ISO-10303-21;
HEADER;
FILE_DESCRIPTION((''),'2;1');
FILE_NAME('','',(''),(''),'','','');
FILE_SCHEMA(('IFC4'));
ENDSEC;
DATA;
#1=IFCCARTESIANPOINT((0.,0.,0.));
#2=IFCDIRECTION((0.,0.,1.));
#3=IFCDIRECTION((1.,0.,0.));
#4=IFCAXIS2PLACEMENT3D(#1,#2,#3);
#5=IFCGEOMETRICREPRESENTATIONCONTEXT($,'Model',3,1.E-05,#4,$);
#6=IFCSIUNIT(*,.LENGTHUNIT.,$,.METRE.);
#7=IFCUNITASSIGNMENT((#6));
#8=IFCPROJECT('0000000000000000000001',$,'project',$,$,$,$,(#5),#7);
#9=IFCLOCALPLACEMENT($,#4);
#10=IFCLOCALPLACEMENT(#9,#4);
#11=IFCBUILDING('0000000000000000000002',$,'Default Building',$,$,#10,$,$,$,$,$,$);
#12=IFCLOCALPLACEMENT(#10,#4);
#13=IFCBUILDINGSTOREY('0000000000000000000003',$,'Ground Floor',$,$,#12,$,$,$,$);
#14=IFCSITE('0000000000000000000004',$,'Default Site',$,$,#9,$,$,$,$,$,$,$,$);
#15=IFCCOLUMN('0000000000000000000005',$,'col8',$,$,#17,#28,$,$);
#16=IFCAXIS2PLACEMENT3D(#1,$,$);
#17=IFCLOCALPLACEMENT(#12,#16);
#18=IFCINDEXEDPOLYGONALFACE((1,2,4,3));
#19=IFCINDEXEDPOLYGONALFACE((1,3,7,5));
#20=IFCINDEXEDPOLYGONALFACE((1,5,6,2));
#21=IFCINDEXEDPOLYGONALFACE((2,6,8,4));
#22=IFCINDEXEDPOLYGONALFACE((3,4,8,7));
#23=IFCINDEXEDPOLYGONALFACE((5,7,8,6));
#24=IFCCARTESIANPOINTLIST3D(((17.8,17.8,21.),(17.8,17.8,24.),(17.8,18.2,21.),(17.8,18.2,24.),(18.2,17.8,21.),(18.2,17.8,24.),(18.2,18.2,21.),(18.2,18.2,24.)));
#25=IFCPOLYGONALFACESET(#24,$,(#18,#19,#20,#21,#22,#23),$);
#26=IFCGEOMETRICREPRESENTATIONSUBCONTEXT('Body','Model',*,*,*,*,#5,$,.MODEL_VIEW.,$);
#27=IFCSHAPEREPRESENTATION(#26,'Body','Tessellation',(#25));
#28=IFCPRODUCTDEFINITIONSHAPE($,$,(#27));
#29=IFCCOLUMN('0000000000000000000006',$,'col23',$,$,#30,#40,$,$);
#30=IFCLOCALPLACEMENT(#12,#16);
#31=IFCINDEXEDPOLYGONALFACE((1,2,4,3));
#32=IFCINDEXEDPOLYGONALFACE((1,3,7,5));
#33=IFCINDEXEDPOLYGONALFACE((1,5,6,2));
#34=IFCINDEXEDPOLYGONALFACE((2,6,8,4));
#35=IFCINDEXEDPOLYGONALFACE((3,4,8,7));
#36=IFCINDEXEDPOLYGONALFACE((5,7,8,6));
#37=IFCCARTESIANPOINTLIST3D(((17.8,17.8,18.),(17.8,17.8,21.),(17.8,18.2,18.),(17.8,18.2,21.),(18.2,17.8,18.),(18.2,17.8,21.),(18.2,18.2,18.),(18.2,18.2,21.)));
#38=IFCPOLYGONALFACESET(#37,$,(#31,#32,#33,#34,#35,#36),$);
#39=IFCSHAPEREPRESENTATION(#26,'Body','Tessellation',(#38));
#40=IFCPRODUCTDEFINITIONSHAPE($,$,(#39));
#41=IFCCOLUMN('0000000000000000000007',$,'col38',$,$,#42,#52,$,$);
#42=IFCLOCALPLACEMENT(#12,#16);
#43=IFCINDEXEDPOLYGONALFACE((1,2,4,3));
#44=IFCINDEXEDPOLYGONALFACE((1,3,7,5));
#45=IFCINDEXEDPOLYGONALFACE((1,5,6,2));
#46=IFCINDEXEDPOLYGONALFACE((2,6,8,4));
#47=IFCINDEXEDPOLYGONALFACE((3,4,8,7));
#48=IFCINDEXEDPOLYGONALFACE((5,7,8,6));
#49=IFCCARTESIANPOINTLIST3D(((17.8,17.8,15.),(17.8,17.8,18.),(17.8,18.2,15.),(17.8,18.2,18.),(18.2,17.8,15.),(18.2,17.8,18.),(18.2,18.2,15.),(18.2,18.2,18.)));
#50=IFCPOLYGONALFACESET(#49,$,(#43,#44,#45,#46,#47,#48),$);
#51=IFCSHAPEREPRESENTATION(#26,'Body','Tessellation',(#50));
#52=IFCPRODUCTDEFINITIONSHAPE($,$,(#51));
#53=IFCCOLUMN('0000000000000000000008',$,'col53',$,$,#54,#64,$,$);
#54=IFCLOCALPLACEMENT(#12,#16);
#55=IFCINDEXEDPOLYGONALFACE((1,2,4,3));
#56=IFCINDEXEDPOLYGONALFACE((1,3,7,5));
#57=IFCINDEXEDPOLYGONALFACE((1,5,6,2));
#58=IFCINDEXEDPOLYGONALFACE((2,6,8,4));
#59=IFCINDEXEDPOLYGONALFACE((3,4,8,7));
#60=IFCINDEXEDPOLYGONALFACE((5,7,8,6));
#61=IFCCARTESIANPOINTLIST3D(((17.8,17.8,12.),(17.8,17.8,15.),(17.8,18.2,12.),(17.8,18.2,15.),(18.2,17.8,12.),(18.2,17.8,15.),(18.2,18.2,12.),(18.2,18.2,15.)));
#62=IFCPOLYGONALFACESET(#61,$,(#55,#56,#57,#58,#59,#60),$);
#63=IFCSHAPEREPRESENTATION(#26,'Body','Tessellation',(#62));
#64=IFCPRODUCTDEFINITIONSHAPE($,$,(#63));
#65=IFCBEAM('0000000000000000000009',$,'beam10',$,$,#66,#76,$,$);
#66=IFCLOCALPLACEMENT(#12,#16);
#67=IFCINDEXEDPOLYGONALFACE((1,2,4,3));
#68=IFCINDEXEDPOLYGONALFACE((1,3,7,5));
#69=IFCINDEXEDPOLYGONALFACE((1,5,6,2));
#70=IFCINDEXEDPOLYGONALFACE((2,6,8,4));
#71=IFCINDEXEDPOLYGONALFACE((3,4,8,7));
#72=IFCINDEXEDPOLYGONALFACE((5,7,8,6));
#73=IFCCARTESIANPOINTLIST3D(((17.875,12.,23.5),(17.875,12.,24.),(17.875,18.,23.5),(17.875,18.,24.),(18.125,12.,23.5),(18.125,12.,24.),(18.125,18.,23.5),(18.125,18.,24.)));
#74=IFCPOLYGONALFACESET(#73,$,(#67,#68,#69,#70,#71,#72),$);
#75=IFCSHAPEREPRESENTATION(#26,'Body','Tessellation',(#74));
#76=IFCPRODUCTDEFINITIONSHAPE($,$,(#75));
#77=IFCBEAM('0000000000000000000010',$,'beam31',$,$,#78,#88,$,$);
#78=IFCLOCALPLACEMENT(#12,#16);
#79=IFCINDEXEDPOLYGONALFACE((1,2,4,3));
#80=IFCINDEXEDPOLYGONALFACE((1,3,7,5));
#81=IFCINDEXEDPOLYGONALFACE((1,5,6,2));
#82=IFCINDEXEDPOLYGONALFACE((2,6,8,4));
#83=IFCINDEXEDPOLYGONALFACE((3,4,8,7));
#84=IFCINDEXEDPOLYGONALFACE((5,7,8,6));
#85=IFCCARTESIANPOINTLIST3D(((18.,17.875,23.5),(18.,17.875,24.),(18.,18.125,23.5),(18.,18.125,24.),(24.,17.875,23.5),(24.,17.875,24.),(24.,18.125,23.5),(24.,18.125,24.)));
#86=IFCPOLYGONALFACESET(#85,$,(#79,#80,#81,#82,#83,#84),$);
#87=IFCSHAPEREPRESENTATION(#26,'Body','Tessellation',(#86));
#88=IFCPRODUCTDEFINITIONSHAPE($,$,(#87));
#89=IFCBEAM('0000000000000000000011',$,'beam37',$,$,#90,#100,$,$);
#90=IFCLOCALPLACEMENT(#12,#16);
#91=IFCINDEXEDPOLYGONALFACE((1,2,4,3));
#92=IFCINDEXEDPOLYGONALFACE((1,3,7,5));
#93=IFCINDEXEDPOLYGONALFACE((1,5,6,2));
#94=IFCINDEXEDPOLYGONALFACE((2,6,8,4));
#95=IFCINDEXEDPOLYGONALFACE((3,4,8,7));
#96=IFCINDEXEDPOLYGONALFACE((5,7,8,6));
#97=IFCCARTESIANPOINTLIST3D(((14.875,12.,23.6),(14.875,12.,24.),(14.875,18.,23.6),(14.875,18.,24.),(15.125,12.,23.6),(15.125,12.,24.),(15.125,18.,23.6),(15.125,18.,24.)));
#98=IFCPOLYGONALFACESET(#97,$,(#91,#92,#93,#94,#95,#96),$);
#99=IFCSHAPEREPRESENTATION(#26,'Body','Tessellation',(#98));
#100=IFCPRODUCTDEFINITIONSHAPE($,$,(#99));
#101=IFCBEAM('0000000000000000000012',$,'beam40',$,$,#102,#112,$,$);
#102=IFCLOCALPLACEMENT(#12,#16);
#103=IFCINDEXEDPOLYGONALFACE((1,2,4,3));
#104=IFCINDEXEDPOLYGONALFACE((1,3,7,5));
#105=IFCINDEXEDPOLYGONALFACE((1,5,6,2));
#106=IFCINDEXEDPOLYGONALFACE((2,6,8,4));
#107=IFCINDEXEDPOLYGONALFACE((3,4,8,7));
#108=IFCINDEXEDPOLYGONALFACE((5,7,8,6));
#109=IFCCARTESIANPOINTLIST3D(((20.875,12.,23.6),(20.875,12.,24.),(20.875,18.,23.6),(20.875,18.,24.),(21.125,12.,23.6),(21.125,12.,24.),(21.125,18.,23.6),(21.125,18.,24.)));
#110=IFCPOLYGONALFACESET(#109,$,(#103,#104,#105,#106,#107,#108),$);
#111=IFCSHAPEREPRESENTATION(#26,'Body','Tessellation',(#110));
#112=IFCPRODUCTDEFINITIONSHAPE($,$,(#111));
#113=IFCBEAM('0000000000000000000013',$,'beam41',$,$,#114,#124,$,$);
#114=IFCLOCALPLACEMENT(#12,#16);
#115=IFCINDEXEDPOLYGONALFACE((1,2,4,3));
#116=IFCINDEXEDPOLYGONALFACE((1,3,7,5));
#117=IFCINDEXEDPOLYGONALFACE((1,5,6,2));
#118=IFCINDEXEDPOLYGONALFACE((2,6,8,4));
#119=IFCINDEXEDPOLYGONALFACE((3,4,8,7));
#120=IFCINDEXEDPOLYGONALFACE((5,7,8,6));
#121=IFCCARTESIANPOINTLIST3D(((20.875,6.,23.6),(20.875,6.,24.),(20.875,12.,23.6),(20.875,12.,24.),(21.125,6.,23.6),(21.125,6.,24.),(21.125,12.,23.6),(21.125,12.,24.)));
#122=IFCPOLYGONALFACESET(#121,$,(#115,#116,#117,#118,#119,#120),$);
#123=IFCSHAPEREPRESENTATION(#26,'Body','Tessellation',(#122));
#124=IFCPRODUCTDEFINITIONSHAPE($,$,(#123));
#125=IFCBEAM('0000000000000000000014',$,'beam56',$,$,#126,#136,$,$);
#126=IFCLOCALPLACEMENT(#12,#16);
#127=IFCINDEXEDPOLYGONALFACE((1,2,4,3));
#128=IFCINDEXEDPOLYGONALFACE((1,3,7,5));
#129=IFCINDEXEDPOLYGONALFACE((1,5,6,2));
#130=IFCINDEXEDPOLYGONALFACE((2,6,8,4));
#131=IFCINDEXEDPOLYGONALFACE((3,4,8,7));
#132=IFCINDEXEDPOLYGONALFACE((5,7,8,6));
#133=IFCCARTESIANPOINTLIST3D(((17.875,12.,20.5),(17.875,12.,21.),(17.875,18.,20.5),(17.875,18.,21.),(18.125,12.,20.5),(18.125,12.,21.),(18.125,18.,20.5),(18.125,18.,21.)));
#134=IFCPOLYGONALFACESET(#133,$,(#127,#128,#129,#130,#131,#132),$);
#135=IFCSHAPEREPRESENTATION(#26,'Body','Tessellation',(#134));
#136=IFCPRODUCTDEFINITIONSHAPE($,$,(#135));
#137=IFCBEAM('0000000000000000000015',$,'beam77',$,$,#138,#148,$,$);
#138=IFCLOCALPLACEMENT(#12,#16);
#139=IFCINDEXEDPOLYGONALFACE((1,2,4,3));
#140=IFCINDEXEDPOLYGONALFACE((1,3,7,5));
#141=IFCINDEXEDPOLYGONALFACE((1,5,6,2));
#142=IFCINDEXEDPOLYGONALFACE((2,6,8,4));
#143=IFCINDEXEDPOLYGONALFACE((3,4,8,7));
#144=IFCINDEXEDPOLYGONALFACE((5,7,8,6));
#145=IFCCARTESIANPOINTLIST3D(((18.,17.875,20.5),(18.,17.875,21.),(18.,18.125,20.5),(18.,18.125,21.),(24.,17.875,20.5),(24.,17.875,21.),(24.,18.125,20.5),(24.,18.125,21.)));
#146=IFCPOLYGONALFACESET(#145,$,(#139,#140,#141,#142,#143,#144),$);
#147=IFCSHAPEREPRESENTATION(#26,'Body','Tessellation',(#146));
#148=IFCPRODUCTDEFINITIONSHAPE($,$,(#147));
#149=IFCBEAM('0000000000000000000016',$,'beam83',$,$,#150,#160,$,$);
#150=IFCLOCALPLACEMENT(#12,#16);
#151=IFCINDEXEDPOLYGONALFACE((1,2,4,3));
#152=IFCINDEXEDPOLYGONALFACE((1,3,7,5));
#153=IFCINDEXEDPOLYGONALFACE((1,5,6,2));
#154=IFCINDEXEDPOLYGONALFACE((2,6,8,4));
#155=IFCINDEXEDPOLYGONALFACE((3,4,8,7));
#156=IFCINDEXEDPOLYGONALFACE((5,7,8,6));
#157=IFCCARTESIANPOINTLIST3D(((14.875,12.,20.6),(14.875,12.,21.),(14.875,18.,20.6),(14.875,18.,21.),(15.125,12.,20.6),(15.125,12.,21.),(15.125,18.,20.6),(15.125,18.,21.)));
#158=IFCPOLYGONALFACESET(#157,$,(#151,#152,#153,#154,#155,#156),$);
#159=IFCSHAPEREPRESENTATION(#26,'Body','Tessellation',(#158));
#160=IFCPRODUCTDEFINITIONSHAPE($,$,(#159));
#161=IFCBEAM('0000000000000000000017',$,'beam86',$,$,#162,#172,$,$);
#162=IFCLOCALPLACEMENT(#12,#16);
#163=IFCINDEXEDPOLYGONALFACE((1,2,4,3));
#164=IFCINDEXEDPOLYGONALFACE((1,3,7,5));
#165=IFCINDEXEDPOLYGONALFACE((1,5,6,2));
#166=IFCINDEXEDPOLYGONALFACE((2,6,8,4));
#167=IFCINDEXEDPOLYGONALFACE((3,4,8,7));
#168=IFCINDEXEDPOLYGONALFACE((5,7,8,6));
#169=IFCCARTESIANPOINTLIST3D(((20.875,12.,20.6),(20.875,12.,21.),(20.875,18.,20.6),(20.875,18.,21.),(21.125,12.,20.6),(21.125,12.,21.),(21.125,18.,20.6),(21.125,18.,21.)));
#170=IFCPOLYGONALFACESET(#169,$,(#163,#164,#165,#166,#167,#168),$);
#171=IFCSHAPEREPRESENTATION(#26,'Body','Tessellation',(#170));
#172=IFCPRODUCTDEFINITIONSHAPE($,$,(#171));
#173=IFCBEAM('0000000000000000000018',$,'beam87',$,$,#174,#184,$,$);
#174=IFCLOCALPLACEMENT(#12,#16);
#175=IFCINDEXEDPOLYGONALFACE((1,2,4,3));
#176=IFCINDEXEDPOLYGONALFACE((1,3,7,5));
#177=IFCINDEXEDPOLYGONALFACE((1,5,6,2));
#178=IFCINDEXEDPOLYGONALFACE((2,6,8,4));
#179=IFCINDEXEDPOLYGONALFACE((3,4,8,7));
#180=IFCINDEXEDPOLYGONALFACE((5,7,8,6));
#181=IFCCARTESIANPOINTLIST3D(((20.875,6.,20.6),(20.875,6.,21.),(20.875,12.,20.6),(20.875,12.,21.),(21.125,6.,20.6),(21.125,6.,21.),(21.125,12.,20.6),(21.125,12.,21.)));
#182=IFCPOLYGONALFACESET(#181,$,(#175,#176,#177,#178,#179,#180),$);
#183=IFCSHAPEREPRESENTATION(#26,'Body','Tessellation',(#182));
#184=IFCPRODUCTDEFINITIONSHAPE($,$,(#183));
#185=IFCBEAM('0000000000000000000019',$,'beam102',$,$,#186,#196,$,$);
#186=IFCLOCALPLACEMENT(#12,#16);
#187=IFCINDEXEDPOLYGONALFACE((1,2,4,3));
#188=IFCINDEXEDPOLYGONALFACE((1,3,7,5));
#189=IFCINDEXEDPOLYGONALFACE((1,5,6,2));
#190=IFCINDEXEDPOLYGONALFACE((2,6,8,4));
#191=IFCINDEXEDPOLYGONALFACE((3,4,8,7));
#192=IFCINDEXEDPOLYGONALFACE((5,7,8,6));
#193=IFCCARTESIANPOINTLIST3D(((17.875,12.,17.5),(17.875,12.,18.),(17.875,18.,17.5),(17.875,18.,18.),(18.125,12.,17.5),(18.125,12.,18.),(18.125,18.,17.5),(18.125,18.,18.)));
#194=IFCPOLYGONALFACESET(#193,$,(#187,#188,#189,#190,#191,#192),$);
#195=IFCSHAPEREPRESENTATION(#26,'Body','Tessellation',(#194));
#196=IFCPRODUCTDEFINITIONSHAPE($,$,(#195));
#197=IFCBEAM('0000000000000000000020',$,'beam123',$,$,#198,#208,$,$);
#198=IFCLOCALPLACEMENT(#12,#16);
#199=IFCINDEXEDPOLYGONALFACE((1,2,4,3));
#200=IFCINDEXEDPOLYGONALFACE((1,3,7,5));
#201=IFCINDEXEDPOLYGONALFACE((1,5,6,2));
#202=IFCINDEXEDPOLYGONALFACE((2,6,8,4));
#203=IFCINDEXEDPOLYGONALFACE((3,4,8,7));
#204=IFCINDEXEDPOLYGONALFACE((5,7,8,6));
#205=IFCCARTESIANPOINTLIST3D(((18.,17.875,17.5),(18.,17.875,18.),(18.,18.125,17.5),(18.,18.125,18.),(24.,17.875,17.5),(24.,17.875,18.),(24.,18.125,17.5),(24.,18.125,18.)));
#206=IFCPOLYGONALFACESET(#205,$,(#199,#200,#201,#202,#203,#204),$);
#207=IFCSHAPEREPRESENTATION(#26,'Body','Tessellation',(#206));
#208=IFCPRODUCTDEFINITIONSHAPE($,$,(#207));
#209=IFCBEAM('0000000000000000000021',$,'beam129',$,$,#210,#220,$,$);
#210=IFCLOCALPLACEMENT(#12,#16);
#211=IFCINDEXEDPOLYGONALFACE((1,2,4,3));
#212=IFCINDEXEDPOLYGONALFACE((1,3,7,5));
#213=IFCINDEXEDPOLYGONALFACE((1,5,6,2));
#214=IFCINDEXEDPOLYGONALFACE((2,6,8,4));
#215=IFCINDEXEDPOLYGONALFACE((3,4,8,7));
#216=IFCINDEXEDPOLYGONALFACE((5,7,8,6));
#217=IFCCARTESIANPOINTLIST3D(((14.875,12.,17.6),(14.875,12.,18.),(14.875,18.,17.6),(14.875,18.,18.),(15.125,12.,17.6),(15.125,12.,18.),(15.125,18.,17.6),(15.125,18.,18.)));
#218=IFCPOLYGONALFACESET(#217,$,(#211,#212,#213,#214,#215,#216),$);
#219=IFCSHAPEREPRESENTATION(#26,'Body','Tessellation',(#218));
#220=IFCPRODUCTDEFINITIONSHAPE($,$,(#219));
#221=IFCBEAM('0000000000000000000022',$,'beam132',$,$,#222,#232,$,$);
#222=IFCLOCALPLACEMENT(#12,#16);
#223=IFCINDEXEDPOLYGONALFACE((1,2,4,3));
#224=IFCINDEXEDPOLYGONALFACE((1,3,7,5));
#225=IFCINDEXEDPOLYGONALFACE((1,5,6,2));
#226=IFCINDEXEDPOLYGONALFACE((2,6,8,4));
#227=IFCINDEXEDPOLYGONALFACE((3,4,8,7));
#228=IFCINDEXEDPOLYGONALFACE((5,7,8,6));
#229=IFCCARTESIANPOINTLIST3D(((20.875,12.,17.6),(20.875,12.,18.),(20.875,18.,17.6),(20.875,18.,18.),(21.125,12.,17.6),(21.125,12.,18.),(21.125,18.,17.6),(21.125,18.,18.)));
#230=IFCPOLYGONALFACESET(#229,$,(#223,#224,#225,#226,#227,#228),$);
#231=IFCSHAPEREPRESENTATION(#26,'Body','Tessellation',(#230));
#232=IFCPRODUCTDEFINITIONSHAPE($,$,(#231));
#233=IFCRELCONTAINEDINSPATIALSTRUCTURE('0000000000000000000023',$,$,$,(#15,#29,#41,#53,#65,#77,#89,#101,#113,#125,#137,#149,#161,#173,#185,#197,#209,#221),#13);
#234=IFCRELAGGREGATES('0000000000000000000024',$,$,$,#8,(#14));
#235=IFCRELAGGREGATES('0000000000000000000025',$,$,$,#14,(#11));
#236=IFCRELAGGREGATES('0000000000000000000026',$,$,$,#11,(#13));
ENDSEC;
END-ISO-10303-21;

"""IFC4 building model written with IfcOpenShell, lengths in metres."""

from ifc_helpers import new_model, si_unit, frame, origin_with_axes, place, context, subcontext, project, spatial, indexed_curve, outline, extrude, element, save


model = new_model("IFC4")

# Units and contexts
model_context = context("Model", 3, precision=1e-05, world=origin_with_axes())
body_context = subcontext(model_context, "Body", "Model", "MODEL_VIEW")
ifc_project = project(units=[si_unit("LENGTHUNIT", "METRE")], contexts=[model_context])

# Site, building, storey
site_placement = place(None, origin_with_axes())
site = spatial("IfcSite", under=ifc_project, at=site_placement, Name="Default Site")
building_placement = place(site_placement, origin_with_axes())
building = spatial("IfcBuilding", under=site, at=building_placement, Name="Default Building")
storey_placement = place(building_placement, origin_with_axes())
storey = spatial("IfcBuildingStorey", under=building, at=storey_placement, Name="Ground Floor")

# Columns
for number, where, z_axis, x_axis, name in (
    (1, (17.8, 17.8, 21.0), (0.0, 0.0, 1.0), (1.0, 0.0, 0.0), "col8"),
    (2, (17.8, 17.8, 18.0), (0.0, 0.0, 1.0), (1.0, 0.0, 0.0), "col23"),
    (3, (17.8, 17.8, 15.0), (0.0, 0.0, 1.0), (1.0, 0.0, 0.0), "col38"),
    (4, (17.8, 17.8, 12.0), (0.0, 0.0, 1.0), (1.0, 0.0, 0.0), "col53"),
):
    element("IfcColumn", number, at=place(storey_placement, frame(where, z_axis=z_axis, x_axis=x_axis)), inside=storey, Name=name, context=body_context, shape_type="SweptSolid", body=[
        extrude(outline(indexed_curve([(0.0, 0.0), (0.0, 0.4), (0.4, 0.4), (0.4, 0.0), (0.0, 0.0)], self_intersect=False)), origin_with_axes(), (0.0, 0.0, 1.0), 3.0),
    ])

# Beams
for number, where, z_axis, x_axis, name in (
    (5, (18.125, 12.0, 23.5), (0.0, 0.0, 1.0), (0.0, 1.0, 0.0), "beam10"),
    (6, (18.0, 17.875, 23.5), (0.0, 0.0, 1.0), (1.0, 0.0, 0.0), "beam31"),
):
    element("IfcBeam", number, at=place(storey_placement, frame(where, z_axis=z_axis, x_axis=x_axis)), inside=storey, Name=name, context=body_context, shape_type="SweptSolid", body=[
        extrude(outline(indexed_curve([(0.0, 0.0), (0.0, 0.25), (6.0, 0.25), (6.0, 0.0), (0.0, 0.0)], self_intersect=False)), origin_with_axes(), (0.0, 0.0, 1.0), 0.5),
    ])
for number, where, z_axis, x_axis, name in (
    (7, (14.875, 18.0, 23.6), (0.0, 0.0, 1.0), (0.0, -1.0, 0.0), "beam37"),
    (8, (20.875, 18.0, 23.6), (0.0, 0.0, 1.0), (0.0, -1.0, 0.0), "beam40"),
    (9, (20.875, 12.0, 23.6), (0.0, 0.0, 1.0), (0.0, -1.0, 0.0), "beam41"),
):
    element("IfcBeam", number, at=place(storey_placement, frame(where, z_axis=z_axis, x_axis=x_axis)), inside=storey, Name=name, context=body_context, shape_type="SweptSolid", body=[
        extrude(outline(indexed_curve([(0.0, 0.0), (0.0, 0.25), (6.0, 0.25), (6.0, 0.0), (0.0, 0.0)], self_intersect=False)), origin_with_axes(), (0.0, 0.0, 1.0), 0.4),
    ])
for number, where, z_axis, x_axis, name in (
    (10, (18.125, 12.0, 20.5), (0.0, 0.0, 1.0), (0.0, 1.0, 0.0), "beam56"),
    (11, (18.0, 17.875, 20.5), (0.0, 0.0, 1.0), (1.0, 0.0, 0.0), "beam77"),
):
    element("IfcBeam", number, at=place(storey_placement, frame(where, z_axis=z_axis, x_axis=x_axis)), inside=storey, Name=name, context=body_context, shape_type="SweptSolid", body=[
        extrude(outline(indexed_curve([(0.0, 0.0), (0.0, 0.25), (6.0, 0.25), (6.0, 0.0), (0.0, 0.0)], self_intersect=False)), origin_with_axes(), (0.0, 0.0, 1.0), 0.5),
    ])
for number, where, z_axis, x_axis, name in (
    (12, (14.875, 18.0, 20.6), (0.0, 0.0, 1.0), (0.0, -1.0, 0.0), "beam83"),
    (13, (20.875, 18.0, 20.6), (0.0, 0.0, 1.0), (0.0, -1.0, 0.0), "beam86"),
    (14, (20.875, 12.0, 20.6), (0.0, 0.0, 1.0), (0.0, -1.0, 0.0), "beam87"),
):
    element("IfcBeam", number, at=place(storey_placement, frame(where, z_axis=z_axis, x_axis=x_axis)), inside=storey, Name=name, context=body_context, shape_type="SweptSolid", body=[
        extrude(outline(indexed_curve([(0.0, 0.0), (0.0, 0.25), (6.0, 0.25), (6.0, 0.0), (0.0, 0.0)], self_intersect=False)), origin_with_axes(), (0.0, 0.0, 1.0), 0.4),
    ])
for number, where, z_axis, x_axis, name in (
    (15, (18.125, 12.0, 17.5), (0.0, 0.0, 1.0), (0.0, 1.0, 0.0), "beam102"),
    (16, (18.0, 17.875, 17.5), (0.0, 0.0, 1.0), (1.0, 0.0, 0.0), "beam123"),
):
    element("IfcBeam", number, at=place(storey_placement, frame(where, z_axis=z_axis, x_axis=x_axis)), inside=storey, Name=name, context=body_context, shape_type="SweptSolid", body=[
        extrude(outline(indexed_curve([(0.0, 0.0), (0.0, 0.25), (6.0, 0.25), (6.0, 0.0), (0.0, 0.0)], self_intersect=False)), origin_with_axes(), (0.0, 0.0, 1.0), 0.5),
    ])
for number, where, z_axis, x_axis, name in (
    (17, (14.875, 18.0, 17.6), (0.0, 0.0, 1.0), (0.0, -1.0, 0.0), "beam129"),
    (18, (20.875, 18.0, 17.6), (0.0, 0.0, 1.0), (0.0, -1.0, 0.0), "beam132"),
):
    element("IfcBeam", number, at=place(storey_placement, frame(where, z_axis=z_axis, x_axis=x_axis)), inside=storey, Name=name, context=body_context, shape_type="SweptSolid", body=[
        extrude(outline(indexed_curve([(0.0, 0.0), (0.0, 0.25), (6.0, 0.25), (6.0, 0.0), (0.0, 0.0)], self_intersect=False)), origin_with_axes(), (0.0, 0.0, 1.0), 0.4),
    ])

save(model, "model.ifc")
